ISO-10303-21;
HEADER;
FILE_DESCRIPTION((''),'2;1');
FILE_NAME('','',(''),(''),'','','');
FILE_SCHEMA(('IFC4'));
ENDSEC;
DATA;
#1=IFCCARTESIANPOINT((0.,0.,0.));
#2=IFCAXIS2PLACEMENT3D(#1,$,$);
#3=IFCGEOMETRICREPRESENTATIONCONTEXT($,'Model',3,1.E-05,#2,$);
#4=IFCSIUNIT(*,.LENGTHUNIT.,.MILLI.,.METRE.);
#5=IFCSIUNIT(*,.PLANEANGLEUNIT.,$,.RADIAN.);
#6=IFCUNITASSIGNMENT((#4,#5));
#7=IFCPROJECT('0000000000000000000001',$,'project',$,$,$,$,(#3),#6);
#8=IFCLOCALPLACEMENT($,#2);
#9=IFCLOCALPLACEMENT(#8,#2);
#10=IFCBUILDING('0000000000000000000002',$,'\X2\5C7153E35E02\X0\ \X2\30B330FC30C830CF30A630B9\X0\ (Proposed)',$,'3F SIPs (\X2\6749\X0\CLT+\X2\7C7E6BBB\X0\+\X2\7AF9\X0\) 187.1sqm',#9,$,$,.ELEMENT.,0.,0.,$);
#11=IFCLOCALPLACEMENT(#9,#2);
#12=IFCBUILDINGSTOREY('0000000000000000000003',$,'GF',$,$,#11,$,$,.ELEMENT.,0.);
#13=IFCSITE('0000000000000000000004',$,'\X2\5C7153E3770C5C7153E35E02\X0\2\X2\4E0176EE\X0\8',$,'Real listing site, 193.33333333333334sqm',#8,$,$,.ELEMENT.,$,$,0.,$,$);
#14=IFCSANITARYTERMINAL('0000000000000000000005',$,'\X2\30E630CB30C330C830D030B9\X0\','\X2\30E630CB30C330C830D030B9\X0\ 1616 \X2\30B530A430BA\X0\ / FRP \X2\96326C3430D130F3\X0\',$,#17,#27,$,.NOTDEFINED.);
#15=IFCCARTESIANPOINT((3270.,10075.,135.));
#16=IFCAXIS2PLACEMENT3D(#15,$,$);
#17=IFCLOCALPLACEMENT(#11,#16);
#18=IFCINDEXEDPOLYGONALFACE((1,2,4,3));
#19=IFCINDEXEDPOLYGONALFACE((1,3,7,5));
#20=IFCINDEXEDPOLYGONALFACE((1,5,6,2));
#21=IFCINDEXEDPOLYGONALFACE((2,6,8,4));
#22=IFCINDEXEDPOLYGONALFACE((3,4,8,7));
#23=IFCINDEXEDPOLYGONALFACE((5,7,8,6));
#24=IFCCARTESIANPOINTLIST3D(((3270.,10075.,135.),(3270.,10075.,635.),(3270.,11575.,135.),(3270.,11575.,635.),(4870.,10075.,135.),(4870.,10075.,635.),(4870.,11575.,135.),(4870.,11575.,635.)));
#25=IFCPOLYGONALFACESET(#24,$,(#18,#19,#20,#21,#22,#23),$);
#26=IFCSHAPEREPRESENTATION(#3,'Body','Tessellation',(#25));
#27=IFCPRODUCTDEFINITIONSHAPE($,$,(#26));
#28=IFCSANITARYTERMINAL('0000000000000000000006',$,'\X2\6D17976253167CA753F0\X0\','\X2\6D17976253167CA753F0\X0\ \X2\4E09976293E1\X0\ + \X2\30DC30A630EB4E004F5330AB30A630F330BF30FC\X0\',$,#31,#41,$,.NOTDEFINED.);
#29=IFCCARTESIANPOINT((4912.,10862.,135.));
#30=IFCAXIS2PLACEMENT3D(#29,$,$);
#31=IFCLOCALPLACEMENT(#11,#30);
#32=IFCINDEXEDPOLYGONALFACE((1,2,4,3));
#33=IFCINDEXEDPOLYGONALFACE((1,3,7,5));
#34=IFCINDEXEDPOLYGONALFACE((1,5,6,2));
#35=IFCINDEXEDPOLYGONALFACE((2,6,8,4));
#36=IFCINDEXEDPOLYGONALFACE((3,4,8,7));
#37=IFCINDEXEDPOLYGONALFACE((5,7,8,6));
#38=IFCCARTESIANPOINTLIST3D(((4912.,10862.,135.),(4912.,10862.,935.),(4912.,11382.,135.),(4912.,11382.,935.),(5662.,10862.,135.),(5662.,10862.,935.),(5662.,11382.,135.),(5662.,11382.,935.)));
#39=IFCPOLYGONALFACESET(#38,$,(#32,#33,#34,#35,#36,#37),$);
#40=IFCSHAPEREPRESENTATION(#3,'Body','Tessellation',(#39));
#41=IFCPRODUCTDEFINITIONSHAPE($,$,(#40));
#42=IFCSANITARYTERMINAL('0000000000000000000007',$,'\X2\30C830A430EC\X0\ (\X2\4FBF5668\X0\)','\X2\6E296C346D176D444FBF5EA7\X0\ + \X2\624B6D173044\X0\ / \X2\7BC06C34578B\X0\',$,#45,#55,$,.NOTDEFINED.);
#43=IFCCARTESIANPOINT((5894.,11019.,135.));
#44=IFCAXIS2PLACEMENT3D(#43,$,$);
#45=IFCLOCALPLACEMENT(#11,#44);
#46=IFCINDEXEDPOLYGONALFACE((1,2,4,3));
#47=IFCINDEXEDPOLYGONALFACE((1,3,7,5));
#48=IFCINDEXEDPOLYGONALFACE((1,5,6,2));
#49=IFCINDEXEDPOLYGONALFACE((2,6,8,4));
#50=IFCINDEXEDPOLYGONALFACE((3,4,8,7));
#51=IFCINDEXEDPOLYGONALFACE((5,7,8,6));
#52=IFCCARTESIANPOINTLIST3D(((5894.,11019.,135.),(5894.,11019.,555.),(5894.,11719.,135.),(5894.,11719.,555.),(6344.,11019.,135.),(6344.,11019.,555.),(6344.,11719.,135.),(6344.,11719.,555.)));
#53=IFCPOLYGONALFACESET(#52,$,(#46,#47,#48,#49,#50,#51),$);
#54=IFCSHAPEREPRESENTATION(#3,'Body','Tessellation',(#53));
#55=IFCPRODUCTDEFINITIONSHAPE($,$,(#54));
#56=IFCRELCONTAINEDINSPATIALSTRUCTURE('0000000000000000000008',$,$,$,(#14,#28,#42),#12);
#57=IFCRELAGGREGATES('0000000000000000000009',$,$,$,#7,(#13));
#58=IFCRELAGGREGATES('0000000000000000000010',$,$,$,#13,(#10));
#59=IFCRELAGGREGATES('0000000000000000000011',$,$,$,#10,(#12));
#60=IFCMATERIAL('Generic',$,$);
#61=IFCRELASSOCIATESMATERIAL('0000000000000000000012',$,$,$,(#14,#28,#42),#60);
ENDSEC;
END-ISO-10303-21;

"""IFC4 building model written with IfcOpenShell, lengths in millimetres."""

from ifc_helpers import new_model, si_unit, frame, frame_2d, origin, place, context, project, spatial, rectangle, extrude, material, element, save


model = new_model("IFC4")

# Units and contexts
model_context = context("Model", 3, precision=1e-05, world=origin())
ifc_project = project(units=[si_unit("LENGTHUNIT", "METRE", prefix="MILLI"), si_unit("PLANEANGLEUNIT", "RADIAN")], contexts=[model_context])

# Site, building, storey
site_placement = place(None, origin())
site = spatial("IfcSite", under=ifc_project, at=site_placement, Name="山口県山口市2丁目8", ObjectType="Real listing site, 193.33333333333334sqm", CompositionType="ELEMENT", RefElevation=0.0)
building_placement = place(site_placement, origin())
building = spatial("IfcBuilding", under=site, at=building_placement, Name="山口市 コートハウス (Proposed)", ObjectType="3F SIPs (杉CLT+籾殻+竹) 187.1sqm", CompositionType="ELEMENT", ElevationOfRefHeight=0.0, ElevationOfTerrain=0.0)
storey_placement = place(building_placement, origin())
storey = spatial("IfcBuildingStorey", under=building, at=storey_placement, Name="GF", CompositionType="ELEMENT", Elevation=0.0)

# Shared definitions
ifc_material_1 = material(Name="Generic")

# Sanitary terminals
sanitary_terminal_1_placement = place(storey_placement, frame((3270.0, 10075.0, 135.0)))
element("IfcSanitaryTerminal", 1, at=sanitary_terminal_1_placement, inside=storey, material=ifc_material_1, Name="ユニットバス", Description="ユニットバス 1616 サイズ / FRP 防水パン", PredefinedType="NOTDEFINED", context=model_context, shape_type="SweptSolid", body=[
    extrude(rectangle(XDim=1600.0, YDim=1500.0, at=frame_2d((800.0, 750.0))), frame((3270.0, 10075.0, 135.0)), (0.0, 0.0, 1.0), 500.0),
])
sanitary_terminal_2_placement = place(storey_placement, frame((4912.0, 10862.0, 135.0)))
element("IfcSanitaryTerminal", 2, at=sanitary_terminal_2_placement, inside=storey, material=ifc_material_1, Name="洗面化粧台", Description="洗面化粧台 三面鏡 + ボウル一体カウンター", PredefinedType="NOTDEFINED", context=model_context, shape_type="SweptSolid", body=[
    extrude(rectangle(XDim=750.0, YDim=520.0, at=frame_2d((375.0, 260.0))), frame((4912.0, 10862.0, 135.0)), (0.0, 0.0, 1.0), 800.0),
])
sanitary_terminal_3_placement = place(storey_placement, frame((5894.0, 11019.0, 135.0)))
element("IfcSanitaryTerminal", 3, at=sanitary_terminal_3_placement, inside=storey, material=ifc_material_1, Name="トイレ (便器)", Description="温水洗浄便座 + 手洗い / 節水型", PredefinedType="NOTDEFINED", context=model_context, shape_type="SweptSolid", body=[
    extrude(rectangle(XDim=450.0, YDim=700.0, at=frame_2d((225.0, 350.0))), frame((5894.0, 11019.0, 135.0)), (0.0, 0.0, 1.0), 420.0),
])

save(model, "model.ifc")
